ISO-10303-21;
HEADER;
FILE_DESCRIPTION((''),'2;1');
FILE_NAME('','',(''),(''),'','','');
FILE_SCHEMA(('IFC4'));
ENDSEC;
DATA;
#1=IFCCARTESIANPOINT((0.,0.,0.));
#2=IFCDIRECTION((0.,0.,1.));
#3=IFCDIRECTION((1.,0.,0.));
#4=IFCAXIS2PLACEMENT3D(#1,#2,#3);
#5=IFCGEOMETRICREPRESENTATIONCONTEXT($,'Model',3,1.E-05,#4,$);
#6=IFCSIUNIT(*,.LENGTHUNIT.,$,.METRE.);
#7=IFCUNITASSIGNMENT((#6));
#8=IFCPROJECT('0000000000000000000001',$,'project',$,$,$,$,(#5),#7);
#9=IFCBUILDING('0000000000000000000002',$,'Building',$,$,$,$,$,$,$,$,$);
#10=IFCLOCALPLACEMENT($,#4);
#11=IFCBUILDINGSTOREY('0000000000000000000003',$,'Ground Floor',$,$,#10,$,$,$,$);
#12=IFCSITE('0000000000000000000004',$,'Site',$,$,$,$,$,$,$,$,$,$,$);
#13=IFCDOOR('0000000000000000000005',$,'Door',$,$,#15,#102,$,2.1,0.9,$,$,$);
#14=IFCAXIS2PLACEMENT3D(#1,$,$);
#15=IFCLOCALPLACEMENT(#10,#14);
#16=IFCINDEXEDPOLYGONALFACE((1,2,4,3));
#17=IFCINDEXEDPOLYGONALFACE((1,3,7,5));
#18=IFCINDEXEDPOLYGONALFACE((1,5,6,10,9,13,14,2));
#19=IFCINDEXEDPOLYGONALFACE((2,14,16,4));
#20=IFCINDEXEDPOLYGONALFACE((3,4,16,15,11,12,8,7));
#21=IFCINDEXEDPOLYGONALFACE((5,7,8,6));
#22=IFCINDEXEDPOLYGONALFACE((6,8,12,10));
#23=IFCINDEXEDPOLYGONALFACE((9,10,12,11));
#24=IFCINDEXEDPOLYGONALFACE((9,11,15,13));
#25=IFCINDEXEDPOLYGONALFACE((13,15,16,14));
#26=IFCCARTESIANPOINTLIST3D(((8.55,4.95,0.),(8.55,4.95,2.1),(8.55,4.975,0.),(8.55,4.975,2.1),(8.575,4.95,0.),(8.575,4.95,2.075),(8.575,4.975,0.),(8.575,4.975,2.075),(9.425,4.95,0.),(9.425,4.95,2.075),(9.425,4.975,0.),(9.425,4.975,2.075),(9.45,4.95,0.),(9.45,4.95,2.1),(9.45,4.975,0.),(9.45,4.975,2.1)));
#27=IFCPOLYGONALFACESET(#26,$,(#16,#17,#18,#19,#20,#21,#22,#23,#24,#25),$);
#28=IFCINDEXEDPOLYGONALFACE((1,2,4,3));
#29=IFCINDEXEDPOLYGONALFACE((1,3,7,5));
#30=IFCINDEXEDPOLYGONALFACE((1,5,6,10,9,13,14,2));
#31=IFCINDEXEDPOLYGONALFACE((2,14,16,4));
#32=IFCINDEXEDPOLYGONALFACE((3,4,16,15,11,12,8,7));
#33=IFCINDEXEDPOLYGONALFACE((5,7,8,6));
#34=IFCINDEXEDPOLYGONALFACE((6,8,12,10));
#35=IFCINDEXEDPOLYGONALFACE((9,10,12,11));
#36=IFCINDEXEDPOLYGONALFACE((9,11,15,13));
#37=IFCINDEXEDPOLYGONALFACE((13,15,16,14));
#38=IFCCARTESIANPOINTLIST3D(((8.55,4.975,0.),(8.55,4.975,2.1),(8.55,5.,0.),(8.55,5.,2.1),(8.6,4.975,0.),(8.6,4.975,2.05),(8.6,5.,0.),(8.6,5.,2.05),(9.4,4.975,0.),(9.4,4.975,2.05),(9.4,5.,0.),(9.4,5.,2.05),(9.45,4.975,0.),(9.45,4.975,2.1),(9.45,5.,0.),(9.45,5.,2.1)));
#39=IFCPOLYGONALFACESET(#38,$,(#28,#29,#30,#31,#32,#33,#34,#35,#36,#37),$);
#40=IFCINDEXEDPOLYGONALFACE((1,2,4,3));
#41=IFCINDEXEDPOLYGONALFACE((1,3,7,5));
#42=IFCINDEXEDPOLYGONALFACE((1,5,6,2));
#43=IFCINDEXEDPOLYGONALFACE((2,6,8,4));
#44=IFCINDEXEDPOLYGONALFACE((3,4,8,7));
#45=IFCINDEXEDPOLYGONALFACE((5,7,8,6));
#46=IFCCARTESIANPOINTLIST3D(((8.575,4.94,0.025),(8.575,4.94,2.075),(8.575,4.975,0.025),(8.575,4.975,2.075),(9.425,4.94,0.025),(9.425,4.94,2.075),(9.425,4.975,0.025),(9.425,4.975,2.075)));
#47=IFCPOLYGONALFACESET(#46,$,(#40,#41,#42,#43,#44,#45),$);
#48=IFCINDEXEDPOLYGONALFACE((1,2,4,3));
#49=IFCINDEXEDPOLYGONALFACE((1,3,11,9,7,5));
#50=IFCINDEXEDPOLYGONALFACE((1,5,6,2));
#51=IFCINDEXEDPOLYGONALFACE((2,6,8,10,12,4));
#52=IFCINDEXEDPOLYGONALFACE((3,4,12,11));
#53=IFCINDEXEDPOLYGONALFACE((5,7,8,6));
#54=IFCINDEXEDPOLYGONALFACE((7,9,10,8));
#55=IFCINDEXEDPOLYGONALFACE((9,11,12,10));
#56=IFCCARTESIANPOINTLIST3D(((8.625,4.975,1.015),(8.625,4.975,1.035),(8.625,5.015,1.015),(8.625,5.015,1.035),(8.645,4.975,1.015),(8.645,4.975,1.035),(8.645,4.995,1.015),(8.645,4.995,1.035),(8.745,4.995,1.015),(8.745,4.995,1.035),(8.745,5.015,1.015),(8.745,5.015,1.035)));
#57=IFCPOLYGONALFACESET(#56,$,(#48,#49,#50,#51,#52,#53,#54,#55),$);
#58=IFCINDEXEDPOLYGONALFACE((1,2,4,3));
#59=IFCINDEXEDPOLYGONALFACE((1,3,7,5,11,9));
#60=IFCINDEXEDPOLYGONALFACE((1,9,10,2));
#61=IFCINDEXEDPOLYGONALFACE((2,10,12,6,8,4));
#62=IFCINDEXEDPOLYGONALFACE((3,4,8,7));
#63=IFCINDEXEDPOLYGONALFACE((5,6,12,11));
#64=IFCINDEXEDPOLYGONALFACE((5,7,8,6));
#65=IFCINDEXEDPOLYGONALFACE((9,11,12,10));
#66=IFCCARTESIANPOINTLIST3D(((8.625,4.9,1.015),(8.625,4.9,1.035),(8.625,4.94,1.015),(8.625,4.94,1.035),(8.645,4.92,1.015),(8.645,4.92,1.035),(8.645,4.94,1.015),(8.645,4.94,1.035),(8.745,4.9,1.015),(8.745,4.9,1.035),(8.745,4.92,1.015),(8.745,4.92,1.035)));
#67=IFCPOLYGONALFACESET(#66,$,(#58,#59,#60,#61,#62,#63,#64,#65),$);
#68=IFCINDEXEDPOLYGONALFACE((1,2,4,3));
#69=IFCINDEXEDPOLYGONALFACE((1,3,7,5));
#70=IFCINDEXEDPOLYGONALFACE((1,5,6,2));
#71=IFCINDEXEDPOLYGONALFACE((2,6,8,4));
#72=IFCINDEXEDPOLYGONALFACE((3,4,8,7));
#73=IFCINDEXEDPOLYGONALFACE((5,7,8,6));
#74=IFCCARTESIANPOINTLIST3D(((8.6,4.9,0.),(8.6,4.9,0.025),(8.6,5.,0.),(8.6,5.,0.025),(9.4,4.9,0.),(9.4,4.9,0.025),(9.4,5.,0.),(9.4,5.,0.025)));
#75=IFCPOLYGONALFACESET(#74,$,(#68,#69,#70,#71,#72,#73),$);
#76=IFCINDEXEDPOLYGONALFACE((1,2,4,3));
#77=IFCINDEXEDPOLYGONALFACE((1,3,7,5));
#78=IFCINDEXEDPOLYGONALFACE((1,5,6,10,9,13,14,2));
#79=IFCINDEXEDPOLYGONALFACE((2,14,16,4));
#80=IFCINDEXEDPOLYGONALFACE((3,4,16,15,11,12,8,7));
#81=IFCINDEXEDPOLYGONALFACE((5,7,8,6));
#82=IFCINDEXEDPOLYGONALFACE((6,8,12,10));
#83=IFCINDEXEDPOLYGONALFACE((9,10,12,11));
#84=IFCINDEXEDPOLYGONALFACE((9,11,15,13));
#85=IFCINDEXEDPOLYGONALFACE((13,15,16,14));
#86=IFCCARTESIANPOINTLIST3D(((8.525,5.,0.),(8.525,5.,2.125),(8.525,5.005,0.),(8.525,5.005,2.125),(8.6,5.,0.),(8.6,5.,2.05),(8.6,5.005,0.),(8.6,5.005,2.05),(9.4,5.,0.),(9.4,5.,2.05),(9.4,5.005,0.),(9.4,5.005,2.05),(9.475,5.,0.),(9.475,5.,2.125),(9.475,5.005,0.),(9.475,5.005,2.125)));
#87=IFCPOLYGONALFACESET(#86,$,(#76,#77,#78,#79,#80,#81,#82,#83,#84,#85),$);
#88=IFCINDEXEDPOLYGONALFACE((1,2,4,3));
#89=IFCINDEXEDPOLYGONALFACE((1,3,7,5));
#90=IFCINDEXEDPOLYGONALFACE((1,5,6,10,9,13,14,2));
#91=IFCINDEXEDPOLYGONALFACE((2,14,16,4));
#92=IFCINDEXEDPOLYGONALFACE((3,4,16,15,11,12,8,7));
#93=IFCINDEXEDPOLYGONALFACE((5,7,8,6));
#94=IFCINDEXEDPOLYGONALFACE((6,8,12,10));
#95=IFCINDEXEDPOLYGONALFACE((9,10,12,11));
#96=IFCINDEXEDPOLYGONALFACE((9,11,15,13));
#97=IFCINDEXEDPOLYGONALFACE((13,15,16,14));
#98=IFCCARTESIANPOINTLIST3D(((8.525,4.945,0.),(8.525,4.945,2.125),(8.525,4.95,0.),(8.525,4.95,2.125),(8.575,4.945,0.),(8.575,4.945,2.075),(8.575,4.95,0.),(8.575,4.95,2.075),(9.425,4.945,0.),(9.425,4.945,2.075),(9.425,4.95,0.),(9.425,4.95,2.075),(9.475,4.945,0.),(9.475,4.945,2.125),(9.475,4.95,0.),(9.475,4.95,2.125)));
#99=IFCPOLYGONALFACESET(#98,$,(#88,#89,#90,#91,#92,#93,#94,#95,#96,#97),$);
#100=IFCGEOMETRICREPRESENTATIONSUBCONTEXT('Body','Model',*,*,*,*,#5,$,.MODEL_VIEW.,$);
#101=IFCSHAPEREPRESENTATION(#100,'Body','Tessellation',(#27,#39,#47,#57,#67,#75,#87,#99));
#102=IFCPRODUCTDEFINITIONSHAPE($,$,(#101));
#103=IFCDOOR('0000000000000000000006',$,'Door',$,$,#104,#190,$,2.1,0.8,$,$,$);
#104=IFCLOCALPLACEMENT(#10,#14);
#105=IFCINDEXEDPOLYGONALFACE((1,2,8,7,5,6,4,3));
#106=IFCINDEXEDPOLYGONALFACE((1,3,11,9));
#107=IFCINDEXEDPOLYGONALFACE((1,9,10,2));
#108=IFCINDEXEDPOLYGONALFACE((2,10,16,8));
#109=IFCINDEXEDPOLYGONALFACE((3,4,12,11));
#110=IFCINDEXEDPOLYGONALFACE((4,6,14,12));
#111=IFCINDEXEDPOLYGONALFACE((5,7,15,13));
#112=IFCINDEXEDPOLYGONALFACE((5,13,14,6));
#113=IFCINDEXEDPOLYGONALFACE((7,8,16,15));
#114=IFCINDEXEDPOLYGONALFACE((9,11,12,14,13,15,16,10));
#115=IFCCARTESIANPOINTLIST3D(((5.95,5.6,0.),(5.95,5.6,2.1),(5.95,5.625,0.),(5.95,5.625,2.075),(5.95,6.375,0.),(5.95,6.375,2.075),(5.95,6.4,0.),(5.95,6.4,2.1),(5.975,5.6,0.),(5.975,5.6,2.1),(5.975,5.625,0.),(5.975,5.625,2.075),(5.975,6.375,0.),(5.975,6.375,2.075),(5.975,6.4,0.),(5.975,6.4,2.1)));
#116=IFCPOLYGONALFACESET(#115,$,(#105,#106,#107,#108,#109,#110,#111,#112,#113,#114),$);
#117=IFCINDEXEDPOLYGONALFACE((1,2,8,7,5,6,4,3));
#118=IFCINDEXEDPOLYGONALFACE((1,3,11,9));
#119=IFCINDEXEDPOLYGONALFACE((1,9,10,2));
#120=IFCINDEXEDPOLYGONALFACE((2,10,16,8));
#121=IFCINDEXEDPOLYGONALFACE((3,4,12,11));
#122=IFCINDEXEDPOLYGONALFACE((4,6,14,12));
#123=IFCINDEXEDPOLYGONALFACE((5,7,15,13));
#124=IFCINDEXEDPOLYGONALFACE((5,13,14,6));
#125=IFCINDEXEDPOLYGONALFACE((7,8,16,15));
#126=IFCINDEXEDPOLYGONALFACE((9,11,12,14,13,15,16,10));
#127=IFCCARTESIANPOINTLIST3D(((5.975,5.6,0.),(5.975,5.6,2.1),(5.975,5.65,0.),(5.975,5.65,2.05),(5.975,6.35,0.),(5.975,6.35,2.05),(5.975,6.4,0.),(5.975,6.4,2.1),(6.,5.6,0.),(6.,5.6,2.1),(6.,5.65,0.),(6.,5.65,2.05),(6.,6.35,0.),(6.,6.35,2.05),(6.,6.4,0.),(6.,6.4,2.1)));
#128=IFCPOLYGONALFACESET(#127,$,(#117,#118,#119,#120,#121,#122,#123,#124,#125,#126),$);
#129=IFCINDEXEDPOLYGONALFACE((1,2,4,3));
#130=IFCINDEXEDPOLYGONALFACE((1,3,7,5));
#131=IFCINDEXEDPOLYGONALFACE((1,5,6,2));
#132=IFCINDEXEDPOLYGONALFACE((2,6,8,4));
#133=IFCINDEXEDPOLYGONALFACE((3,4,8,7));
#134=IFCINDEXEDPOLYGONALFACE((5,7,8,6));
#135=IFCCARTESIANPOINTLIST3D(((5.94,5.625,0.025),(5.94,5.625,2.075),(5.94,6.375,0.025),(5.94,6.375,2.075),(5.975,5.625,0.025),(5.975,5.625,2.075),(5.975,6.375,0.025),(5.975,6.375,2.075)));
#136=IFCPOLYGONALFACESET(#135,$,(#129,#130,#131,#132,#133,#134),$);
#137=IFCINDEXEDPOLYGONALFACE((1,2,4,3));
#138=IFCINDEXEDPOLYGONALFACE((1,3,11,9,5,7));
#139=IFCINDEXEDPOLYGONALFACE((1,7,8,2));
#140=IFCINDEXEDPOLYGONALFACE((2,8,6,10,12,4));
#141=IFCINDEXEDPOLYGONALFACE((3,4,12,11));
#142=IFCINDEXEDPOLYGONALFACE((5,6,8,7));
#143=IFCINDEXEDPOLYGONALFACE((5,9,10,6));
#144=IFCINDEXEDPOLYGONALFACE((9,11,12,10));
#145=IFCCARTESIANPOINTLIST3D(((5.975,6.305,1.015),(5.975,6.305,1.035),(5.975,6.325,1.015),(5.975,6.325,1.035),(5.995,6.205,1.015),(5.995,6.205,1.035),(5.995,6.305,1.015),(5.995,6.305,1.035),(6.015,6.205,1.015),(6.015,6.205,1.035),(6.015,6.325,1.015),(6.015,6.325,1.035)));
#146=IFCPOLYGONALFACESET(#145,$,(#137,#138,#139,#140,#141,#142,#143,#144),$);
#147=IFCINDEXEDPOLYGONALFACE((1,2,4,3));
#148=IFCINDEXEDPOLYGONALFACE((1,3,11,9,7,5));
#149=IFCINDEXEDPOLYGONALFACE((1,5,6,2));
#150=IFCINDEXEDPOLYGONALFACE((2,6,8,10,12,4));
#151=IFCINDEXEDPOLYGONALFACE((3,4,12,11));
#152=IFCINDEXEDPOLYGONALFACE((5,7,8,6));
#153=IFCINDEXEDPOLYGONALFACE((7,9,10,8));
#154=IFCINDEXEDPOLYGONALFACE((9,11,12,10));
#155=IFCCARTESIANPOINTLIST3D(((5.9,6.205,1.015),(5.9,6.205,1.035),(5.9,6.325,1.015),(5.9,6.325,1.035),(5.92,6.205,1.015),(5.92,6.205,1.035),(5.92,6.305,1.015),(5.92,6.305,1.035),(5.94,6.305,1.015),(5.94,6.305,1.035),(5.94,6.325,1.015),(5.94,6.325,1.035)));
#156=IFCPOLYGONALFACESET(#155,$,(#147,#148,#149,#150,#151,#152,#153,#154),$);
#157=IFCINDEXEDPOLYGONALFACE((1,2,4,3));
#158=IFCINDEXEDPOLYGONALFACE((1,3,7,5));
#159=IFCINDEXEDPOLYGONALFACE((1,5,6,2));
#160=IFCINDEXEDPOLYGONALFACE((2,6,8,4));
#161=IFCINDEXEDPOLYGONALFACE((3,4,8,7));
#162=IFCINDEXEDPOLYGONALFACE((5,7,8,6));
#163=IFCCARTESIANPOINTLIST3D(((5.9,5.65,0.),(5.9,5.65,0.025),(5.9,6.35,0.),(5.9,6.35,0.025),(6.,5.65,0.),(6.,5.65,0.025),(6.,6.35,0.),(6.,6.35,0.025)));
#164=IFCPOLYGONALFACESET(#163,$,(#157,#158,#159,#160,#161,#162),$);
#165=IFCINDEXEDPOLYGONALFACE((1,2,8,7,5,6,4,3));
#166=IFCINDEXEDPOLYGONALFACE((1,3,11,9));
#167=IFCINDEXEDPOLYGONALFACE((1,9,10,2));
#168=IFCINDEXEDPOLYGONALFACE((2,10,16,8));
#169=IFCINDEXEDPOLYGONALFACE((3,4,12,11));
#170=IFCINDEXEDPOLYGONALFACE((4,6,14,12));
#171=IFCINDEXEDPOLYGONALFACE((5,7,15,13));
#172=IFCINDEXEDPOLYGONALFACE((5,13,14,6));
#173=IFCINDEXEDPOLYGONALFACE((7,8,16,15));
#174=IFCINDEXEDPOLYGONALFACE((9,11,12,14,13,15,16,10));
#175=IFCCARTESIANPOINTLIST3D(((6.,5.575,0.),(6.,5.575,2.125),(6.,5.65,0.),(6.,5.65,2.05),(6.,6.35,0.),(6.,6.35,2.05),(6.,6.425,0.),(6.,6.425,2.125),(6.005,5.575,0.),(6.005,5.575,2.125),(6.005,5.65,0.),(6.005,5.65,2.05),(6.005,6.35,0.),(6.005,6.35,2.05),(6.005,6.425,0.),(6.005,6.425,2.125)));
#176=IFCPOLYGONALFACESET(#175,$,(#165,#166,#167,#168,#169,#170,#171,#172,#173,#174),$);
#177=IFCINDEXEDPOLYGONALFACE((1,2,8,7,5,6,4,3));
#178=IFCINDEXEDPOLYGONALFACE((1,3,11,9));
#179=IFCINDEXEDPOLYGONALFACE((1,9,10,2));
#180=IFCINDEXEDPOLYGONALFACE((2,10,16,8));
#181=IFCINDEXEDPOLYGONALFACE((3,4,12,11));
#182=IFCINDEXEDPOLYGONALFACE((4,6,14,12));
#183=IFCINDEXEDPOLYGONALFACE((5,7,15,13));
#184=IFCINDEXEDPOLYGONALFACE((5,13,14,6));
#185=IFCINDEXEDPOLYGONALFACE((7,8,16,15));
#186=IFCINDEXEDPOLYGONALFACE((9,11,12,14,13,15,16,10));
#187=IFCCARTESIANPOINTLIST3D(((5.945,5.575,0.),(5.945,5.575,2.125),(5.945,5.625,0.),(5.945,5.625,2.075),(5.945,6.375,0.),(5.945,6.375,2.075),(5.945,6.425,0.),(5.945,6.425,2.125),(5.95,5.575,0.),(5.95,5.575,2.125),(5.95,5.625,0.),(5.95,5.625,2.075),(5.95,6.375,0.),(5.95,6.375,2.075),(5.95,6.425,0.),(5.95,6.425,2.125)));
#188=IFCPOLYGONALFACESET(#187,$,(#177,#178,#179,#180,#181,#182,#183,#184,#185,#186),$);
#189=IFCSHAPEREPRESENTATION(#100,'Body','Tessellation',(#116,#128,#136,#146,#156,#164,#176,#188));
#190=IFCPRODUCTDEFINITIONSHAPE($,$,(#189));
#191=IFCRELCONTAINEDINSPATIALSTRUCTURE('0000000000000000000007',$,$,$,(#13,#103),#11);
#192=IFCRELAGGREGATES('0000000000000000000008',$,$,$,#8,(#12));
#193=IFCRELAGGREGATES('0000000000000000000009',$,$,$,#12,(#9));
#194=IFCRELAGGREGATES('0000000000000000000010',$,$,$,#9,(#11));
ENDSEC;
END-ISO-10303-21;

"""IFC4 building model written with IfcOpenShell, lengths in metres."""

from ifc_helpers import new_model, si_unit, frame, origin_with_axes, place, context, subcontext, project, spatial, line, indexed_curve, outline, extrude, element, save


model = new_model("IFC4")

# Units and contexts
model_context = context("Model", 3, precision=1e-05, world=origin_with_axes())
body_context = subcontext(model_context, "Body", "Model", "MODEL_VIEW")
ifc_project = project(units=[si_unit("LENGTHUNIT", "METRE")], contexts=[model_context])

# Site, building, storey
site = spatial("IfcSite", under=ifc_project, Name="Site")
building = spatial("IfcBuilding", under=site, Name="Building")
storey_placement = place(None, origin_with_axes())
storey = spatial("IfcBuildingStorey", under=building, at=storey_placement, Name="Ground Floor")

# Doors
door_1_placement = place(storey_placement, frame((9.45, 5.0, 0.0), z_axis=(0.0, 0.0, 1.0), x_axis=(-1.0, 0.0, 0.0)))
element("IfcDoor", 1, at=door_1_placement, inside=storey, Name="Door", OverallHeight=2.1, OverallWidth=0.9, context=body_context, shape_type="SweptSolid", body=[
    extrude(outline(indexed_curve([(0.0, 0.0), (0.0, 2.1), (0.9, 2.1), (0.9, 0.0), (0.875, 0.0), (0.875, 2.075), (0.025, 2.075), (0.025, 0.0)], segments=[line(1, 2, 3, 4, 5, 6, 7, 8, 1)])), frame((0.0, 0.025, 0.0), z_axis=(0.0, -1.0, 0.0), x_axis=(1.0, 0.0, 0.0)), (0.0, 0.0, -1.0), 0.025),
    extrude(outline(indexed_curve([(0.0, 0.0), (0.0, 2.1), (0.9, 2.1), (0.9, 0.0), (0.85, 0.0), (0.85, 2.05), (0.05, 2.05), (0.05, 0.0)], segments=[line(1, 2, 3, 4, 5, 6, 7, 8, 1)])), frame((0.0, 0.0, 0.0), z_axis=(0.0, -1.0, 0.0), x_axis=(1.0, 0.0, 0.0)), (0.0, 0.0, -1.0), 0.025),
    extrude(outline(indexed_curve([(0.0, 0.0), (0.85, 0.0), (0.85, 0.035), (0.0, 0.035)], segments=[line(1, 2, 3, 4, 1)])), frame((0.025, 0.025, 0.025), z_axis=(0.0, 0.0, 1.0), x_axis=(1.0, 0.0, 0.0)), (0.0, 0.0, 1.0), 2.05),
    extrude(outline(indexed_curve([(0.0, 0.0), (0.0, -0.04), (-0.12, -0.04), (-0.12, -0.02), (-0.02, -0.02), (-0.02, 0.0)], segments=[line(1, 2, 3, 4, 5, 6, 1)])), frame((0.825, 0.025, 1.015), z_axis=(0.0, 0.0, 1.0), x_axis=(1.0, 0.0, 0.0)), (0.0, 0.0, 1.0), 0.02),
    extrude(outline(indexed_curve([(0.0, 0.0), (0.0, 0.04), (-0.12, 0.04), (-0.12, 0.02), (-0.02, 0.02), (-0.02, 0.0)], segments=[line(1, 2, 3, 4, 5, 6, 1)])), frame((0.825, 0.06, 1.015), z_axis=(0.0, 0.0, 1.0), x_axis=(1.0, 0.0, 0.0)), (0.0, 0.0, 1.0), 0.02),
    extrude(outline(indexed_curve([(0.0, 0.0), (0.8, 0.0), (0.8, 0.1), (0.0, 0.1)], segments=[line(1, 2, 3, 4, 1)])), frame((0.05, 0.0, 0.0), z_axis=(0.0, 0.0, 1.0), x_axis=(1.0, 0.0, 0.0)), (0.0, 0.0, 1.0), 0.025),
    extrude(outline(indexed_curve([(0.0, 0.0), (0.0, 2.125), (0.95, 2.125), (0.95, 0.0), (0.875, 0.0), (0.875, 2.05), (0.075, 2.05), (0.075, 0.0)], segments=[line(1, 2, 3, 4, 5, 6, 7, 8, 1)])), frame((-0.025, -0.005, 0.0), z_axis=(0.0, -1.0, 0.0), x_axis=(1.0, 0.0, 0.0)), (0.0, 0.0, -1.0), 0.005),
    extrude(outline(indexed_curve([(0.0, 0.0), (0.0, 2.125), (0.95, 2.125), (0.95, 0.0), (0.9, 0.0), (0.9, 2.075), (0.05, 2.075), (0.05, 0.0)], segments=[line(1, 2, 3, 4, 5, 6, 7, 8, 1)])), frame((-0.025, 0.05, 0.0), z_axis=(0.0, -1.0, 0.0), x_axis=(1.0, 0.0, 0.0)), (0.0, 0.0, -1.0), 0.005),
])
door_2_placement = place(storey_placement, frame((6.0, 5.6, 0.0), z_axis=(0.0, 0.0, 1.0), x_axis=(0.0, 1.0, 0.0)))
element("IfcDoor", 2, at=door_2_placement, inside=storey, Name="Door", OverallHeight=2.1, OverallWidth=0.8, context=body_context, shape_type="SweptSolid", body=[
    extrude(outline(indexed_curve([(0.0, 0.0), (0.0, 2.1), (0.8, 2.1), (0.8, 0.0), (0.775, 0.0), (0.775, 2.075), (0.025, 2.075), (0.025, 0.0)], segments=[line(1, 2, 3, 4, 5, 6, 7, 8, 1)])), frame((0.0, 0.025, 0.0), z_axis=(0.0, -1.0, 0.0), x_axis=(1.0, 0.0, 0.0)), (0.0, 0.0, -1.0), 0.025),
    extrude(outline(indexed_curve([(0.0, 0.0), (0.0, 2.1), (0.8, 2.1), (0.8, 0.0), (0.75, 0.0), (0.75, 2.05), (0.05, 2.05), (0.05, 0.0)], segments=[line(1, 2, 3, 4, 5, 6, 7, 8, 1)])), frame((0.0, 0.0, 0.0), z_axis=(0.0, -1.0, 0.0), x_axis=(1.0, 0.0, 0.0)), (0.0, 0.0, -1.0), 0.025),
    extrude(outline(indexed_curve([(0.0, 0.0), (0.75, 0.0), (0.75, 0.035), (0.0, 0.035)], segments=[line(1, 2, 3, 4, 1)])), frame((0.025, 0.025, 0.025), z_axis=(0.0, 0.0, 1.0), x_axis=(1.0, 0.0, 0.0)), (0.0, 0.0, 1.0), 2.05),
    extrude(outline(indexed_curve([(0.0, 0.0), (0.0, -0.04), (-0.12, -0.04), (-0.12, -0.02), (-0.02, -0.02), (-0.02, 0.0)], segments=[line(1, 2, 3, 4, 5, 6, 1)])), frame((0.725, 0.025, 1.015), z_axis=(0.0, 0.0, 1.0), x_axis=(1.0, 0.0, 0.0)), (0.0, 0.0, 1.0), 0.02),
    extrude(outline(indexed_curve([(0.0, 0.0), (0.0, 0.04), (-0.12, 0.04), (-0.12, 0.02), (-0.02, 0.02), (-0.02, 0.0)], segments=[line(1, 2, 3, 4, 5, 6, 1)])), frame((0.725, 0.06, 1.015), z_axis=(0.0, 0.0, 1.0), x_axis=(1.0, 0.0, 0.0)), (0.0, 0.0, 1.0), 0.02),
    extrude(outline(indexed_curve([(0.0, 0.0), (0.7, 0.0), (0.7, 0.1), (0.0, 0.1)], segments=[line(1, 2, 3, 4, 1)])), frame((0.05, 0.0, 0.0), z_axis=(0.0, 0.0, 1.0), x_axis=(1.0, 0.0, 0.0)), (0.0, 0.0, 1.0), 0.025),
    extrude(outline(indexed_curve([(0.0, 0.0), (0.0, 2.125), (0.85, 2.125), (0.85, 0.0), (0.775, 0.0), (0.775, 2.05), (0.075, 2.05), (0.075, 0.0)], segments=[line(1, 2, 3, 4, 5, 6, 7, 8, 1)])), frame((-0.025, -0.005, 0.0), z_axis=(0.0, -1.0, 0.0), x_axis=(1.0, 0.0, 0.0)), (0.0, 0.0, -1.0), 0.005),
    extrude(outline(indexed_curve([(0.0, 0.0), (0.0, 2.125), (0.85, 2.125), (0.85, 0.0), (0.8, 0.0), (0.8, 2.075), (0.05, 2.075), (0.05, 0.0)], segments=[line(1, 2, 3, 4, 5, 6, 7, 8, 1)])), frame((-0.025, 0.05, 0.0), z_axis=(0.0, -1.0, 0.0), x_axis=(1.0, 0.0, 0.0)), (0.0, 0.0, -1.0), 0.005),
])

save(model, "model.ifc")
